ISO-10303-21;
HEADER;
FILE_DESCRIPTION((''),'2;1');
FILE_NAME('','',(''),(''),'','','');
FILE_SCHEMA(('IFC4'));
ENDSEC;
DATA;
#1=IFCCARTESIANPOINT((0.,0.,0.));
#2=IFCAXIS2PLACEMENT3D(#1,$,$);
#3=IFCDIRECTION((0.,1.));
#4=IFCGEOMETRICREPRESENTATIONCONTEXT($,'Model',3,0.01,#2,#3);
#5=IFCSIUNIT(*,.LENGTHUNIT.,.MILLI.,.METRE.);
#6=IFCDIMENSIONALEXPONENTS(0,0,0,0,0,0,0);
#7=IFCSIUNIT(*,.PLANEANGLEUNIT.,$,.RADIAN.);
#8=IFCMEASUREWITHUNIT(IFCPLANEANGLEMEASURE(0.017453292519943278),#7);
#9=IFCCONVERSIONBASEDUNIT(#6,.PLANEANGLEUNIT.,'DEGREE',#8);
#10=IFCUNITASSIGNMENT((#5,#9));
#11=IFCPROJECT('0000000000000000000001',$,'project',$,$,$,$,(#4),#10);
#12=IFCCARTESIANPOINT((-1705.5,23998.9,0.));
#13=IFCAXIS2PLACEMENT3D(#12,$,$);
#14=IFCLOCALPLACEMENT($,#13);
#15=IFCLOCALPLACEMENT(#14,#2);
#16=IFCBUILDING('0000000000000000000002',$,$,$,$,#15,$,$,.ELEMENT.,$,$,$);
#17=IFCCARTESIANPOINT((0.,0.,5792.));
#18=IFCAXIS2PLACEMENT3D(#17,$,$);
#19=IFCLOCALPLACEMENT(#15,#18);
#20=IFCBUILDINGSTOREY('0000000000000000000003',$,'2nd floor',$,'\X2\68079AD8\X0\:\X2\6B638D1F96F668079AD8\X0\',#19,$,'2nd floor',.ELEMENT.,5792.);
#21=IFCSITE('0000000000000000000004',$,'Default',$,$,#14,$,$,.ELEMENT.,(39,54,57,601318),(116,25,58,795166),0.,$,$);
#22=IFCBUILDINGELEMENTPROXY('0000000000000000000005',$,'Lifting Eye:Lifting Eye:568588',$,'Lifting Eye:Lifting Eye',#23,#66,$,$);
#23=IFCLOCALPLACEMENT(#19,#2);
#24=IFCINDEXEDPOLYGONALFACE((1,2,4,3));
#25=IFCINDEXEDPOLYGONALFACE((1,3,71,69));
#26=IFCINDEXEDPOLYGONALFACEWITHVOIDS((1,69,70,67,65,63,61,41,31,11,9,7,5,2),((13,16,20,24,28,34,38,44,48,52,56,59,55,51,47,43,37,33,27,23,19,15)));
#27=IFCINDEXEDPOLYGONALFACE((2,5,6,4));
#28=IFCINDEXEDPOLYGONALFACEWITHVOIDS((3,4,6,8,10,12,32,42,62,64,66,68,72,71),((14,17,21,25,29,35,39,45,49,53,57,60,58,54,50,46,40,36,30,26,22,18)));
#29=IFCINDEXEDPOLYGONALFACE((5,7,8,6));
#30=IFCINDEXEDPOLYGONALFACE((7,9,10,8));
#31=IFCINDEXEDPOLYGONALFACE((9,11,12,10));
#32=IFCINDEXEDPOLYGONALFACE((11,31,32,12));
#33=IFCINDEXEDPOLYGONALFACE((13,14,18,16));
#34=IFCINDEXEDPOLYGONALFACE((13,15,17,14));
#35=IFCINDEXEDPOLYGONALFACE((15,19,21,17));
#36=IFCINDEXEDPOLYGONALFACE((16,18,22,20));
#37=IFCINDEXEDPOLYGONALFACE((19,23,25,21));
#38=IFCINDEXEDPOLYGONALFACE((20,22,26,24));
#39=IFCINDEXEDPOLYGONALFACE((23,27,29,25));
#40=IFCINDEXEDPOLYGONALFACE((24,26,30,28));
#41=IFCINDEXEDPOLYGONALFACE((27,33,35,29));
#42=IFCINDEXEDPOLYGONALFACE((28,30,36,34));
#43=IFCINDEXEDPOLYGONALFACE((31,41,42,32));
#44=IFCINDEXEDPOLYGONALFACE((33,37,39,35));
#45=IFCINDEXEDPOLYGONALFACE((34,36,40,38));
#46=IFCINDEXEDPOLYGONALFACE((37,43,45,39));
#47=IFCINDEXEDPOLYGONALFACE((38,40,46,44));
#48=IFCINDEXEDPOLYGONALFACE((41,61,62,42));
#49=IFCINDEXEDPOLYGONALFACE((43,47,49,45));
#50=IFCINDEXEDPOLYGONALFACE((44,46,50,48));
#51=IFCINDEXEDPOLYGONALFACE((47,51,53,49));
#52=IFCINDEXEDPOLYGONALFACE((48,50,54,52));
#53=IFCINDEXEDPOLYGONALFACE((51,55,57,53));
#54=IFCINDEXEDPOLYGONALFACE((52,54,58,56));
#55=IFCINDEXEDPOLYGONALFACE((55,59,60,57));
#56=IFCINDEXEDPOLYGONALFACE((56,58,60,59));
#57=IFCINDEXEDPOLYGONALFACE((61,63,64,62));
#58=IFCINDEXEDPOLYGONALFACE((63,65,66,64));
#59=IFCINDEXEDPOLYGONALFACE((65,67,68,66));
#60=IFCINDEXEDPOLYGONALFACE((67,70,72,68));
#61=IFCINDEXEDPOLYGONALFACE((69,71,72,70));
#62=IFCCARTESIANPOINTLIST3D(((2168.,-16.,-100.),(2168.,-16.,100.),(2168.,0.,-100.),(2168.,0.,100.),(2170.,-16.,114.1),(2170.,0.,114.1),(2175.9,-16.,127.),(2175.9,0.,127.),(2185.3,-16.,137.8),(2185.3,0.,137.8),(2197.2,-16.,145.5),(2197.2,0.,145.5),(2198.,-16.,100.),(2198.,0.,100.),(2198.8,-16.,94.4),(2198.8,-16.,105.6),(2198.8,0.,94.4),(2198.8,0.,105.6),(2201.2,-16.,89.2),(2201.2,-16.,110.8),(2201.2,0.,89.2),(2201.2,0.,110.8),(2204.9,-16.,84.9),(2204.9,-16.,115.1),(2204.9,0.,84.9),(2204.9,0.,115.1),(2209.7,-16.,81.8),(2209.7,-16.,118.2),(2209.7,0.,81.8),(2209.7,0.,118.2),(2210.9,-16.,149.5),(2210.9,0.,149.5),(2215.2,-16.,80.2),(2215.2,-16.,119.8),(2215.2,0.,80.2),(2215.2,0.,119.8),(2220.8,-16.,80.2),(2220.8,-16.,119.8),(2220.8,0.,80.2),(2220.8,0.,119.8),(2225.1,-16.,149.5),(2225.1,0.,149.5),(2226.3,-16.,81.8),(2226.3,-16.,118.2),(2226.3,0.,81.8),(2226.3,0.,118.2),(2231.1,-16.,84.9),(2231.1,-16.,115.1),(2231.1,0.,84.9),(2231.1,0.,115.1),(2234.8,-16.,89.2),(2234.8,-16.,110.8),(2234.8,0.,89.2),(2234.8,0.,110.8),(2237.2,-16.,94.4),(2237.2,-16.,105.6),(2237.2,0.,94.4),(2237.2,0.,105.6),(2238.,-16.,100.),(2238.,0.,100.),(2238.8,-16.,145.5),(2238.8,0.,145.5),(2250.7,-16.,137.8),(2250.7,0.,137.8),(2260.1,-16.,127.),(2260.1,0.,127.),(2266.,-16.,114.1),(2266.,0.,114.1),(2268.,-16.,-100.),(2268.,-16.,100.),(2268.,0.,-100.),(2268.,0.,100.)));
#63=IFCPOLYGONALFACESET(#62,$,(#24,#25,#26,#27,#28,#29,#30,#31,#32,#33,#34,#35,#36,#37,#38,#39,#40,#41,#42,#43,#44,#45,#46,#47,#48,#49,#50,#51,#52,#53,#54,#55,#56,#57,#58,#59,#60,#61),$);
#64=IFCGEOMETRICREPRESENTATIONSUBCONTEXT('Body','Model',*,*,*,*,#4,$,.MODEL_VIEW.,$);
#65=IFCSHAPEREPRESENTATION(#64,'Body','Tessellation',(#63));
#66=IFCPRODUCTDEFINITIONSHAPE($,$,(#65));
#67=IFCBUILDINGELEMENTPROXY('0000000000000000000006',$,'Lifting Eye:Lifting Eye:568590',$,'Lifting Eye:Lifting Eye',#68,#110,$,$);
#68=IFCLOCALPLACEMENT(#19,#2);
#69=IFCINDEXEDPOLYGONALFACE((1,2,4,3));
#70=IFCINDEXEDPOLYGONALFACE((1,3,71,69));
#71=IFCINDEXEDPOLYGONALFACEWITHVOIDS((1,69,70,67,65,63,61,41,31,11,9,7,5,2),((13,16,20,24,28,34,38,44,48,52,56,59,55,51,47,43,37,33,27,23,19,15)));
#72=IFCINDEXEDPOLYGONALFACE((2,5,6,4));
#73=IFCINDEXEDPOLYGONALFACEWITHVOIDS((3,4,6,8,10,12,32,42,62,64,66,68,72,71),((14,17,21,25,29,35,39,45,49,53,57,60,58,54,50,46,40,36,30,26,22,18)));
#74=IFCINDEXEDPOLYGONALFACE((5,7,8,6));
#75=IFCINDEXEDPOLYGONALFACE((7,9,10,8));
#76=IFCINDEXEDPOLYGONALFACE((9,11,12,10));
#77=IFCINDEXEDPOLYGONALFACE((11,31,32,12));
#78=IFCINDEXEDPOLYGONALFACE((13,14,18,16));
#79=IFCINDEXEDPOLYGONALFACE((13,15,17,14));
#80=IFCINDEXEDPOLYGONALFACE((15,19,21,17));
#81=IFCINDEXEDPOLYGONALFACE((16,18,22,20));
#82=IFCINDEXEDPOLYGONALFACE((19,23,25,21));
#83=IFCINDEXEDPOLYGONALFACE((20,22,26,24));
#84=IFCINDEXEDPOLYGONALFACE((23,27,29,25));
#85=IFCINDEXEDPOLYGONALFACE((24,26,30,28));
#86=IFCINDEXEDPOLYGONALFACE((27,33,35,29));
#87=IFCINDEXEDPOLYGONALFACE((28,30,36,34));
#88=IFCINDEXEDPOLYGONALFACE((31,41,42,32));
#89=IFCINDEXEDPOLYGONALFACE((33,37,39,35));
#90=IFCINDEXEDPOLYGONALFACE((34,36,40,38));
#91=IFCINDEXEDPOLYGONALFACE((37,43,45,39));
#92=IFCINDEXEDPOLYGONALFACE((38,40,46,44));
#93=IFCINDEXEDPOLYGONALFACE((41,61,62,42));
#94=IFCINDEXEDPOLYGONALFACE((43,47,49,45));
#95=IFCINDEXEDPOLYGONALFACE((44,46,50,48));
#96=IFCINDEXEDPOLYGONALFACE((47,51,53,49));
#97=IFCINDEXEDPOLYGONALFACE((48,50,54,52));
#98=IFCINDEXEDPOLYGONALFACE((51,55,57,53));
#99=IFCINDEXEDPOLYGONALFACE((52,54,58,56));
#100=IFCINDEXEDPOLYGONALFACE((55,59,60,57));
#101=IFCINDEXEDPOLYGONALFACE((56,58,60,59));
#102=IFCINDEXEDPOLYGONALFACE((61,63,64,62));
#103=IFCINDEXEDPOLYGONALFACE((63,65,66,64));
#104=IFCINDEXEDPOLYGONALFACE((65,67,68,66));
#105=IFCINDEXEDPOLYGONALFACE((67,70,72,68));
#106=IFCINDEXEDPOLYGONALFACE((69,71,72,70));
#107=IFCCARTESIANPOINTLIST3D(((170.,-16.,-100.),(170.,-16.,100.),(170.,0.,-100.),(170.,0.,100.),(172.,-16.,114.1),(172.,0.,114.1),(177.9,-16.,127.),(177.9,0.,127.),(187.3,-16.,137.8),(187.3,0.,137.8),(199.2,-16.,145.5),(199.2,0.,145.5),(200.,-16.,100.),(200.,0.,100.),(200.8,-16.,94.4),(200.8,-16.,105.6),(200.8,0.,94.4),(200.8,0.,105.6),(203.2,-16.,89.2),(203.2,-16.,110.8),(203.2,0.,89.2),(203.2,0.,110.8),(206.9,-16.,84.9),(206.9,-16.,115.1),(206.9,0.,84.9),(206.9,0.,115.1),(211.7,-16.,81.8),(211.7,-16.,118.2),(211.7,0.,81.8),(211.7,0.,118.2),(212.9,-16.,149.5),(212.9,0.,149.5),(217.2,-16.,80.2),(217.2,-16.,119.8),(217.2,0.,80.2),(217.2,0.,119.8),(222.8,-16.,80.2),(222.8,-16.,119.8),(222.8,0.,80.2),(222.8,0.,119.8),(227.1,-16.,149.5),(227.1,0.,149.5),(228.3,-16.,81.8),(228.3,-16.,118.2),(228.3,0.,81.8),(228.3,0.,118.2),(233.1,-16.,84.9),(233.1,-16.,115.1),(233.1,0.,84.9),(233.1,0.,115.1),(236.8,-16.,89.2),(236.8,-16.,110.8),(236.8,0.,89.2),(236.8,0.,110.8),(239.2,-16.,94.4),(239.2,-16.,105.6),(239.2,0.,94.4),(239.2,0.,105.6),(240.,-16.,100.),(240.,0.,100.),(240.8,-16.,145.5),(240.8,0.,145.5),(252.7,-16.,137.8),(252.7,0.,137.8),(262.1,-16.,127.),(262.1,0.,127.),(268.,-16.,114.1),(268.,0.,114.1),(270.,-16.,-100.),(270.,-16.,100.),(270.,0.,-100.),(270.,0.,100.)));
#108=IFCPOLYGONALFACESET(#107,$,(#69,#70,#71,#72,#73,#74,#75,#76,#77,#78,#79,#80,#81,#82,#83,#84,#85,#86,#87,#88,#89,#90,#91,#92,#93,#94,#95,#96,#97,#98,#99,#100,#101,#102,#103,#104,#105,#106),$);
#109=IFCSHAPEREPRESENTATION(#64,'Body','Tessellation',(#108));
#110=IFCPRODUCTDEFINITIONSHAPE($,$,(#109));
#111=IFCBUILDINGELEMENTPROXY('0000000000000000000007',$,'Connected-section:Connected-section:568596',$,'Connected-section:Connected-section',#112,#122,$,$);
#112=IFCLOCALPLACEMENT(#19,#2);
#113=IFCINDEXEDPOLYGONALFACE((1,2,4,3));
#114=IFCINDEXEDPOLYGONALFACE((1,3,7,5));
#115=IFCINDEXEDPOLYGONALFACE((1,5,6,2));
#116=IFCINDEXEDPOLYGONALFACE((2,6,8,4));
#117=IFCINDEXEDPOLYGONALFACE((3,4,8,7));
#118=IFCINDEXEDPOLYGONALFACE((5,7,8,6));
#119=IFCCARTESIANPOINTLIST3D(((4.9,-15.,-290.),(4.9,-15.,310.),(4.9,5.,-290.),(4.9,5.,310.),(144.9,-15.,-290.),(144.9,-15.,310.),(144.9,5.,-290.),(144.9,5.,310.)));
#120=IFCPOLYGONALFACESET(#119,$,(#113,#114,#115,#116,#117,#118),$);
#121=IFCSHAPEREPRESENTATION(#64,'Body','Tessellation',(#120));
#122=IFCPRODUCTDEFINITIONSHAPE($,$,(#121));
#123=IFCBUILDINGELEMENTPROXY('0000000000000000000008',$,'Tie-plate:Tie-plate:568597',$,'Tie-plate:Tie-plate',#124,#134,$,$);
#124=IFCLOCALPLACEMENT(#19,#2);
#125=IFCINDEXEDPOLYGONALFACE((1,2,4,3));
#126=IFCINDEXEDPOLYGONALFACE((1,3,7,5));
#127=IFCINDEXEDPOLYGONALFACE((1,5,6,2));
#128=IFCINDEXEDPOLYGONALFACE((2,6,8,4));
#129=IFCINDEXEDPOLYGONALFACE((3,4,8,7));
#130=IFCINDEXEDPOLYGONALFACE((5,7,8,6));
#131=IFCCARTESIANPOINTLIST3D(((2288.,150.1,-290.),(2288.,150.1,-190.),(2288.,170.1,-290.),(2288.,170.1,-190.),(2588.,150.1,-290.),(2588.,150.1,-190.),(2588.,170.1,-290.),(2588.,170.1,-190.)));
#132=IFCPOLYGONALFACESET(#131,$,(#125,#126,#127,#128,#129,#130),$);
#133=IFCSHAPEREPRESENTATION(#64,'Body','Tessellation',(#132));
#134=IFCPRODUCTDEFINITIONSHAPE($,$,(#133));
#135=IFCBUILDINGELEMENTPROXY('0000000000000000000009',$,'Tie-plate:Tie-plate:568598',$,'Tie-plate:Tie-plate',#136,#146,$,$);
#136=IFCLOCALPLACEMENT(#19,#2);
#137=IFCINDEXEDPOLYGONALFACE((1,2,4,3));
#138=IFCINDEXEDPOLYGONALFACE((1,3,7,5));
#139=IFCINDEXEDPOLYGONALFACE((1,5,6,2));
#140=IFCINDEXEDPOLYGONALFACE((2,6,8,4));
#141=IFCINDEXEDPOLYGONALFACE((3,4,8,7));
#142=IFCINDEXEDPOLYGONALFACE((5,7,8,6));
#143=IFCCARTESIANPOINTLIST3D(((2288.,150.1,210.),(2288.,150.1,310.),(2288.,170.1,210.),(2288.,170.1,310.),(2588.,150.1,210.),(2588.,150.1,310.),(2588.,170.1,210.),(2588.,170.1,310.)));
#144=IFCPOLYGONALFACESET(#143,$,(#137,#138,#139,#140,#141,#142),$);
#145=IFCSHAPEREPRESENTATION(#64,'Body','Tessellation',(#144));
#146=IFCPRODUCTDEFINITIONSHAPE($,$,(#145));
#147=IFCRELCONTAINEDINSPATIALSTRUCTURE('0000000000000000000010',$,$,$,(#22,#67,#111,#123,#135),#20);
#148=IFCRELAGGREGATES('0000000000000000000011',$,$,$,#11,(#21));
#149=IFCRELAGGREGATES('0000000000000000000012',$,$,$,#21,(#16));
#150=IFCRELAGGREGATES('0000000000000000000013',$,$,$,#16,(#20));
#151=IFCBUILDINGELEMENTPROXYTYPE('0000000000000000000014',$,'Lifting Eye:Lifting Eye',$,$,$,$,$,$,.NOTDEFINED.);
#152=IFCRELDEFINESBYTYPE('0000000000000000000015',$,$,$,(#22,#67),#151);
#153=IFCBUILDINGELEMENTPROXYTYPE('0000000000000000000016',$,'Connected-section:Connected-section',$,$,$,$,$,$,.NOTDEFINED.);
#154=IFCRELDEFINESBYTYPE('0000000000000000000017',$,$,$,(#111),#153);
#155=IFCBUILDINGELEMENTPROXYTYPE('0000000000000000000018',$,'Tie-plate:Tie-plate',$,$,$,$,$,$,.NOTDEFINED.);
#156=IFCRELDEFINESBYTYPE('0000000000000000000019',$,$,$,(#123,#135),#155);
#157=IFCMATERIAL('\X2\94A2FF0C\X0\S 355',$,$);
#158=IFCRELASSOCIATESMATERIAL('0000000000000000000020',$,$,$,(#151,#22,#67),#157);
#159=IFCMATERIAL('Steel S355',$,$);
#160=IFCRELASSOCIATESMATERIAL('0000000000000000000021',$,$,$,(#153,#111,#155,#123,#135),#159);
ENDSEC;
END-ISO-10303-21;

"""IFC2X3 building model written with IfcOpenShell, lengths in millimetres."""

from ifc_helpers import new_model, entity, si_unit, converted_unit, direction, frame, frame_2d, origin, place, context, subcontext, project, spatial, polyline, circle_curve, parameter, trimmed, segment, composite_curve, rectangle, outline, extrude, source, transform, mapped, material, type_object, type_shapes, element, save


model = new_model("IFC2X3")

# Units and contexts
model_context = context("Model", 3, precision=0.01, world=origin(), true_north=direction((0.0, 1.0)))
body_context = subcontext(model_context, "Body", "Model", "MODEL_VIEW")
ifc_project = project(units=[si_unit("LENGTHUNIT", "METRE", prefix="MILLI"), converted_unit("PLANEANGLEUNIT", "DEGREE", entity("IfcPlaneAngleMeasure", 0.017453292519943278), si_unit("PLANEANGLEUNIT", "RADIAN"), dimensions=[0, 0, 0, 0, 0, 0, 0])], contexts=[model_context])

# Site, building, storey
site_placement = place(None, frame((-1705.5, 23998.9, 0.0)))
site = spatial("IfcSite", under=ifc_project, at=site_placement, Name="Default", CompositionType="ELEMENT", RefLatitude=(39, 54, 57, 601318), RefLongitude=(116, 25, 58, 795166), RefElevation=0.0)
building_placement = place(site_placement, origin())
building = spatial("IfcBuilding", under=site, at=building_placement, CompositionType="ELEMENT")
storey_placement = place(building_placement, frame((0.0, 0.0, 5792.0)))
storey = spatial("IfcBuildingStorey", under=building, at=storey_placement, Name="2nd floor", ObjectType="标高:正负零标高", LongName="2nd floor", CompositionType="ELEMENT", Elevation=5792.0)

# Shared definitions
ifc_material_1 = material(Name="Steel S355")

# Building element proxies
ifc_material_2 = material(Name="钢，S 355")
building_element_proxy_type_1 = type_object("IfcBuildingElementProxyType", Name="Lifting Eye:Lifting Eye", PredefinedType="NOTDEFINED", material=ifc_material_2)
shared_shape_1 = source(origin(), body_context, "Body", "SweptSolid", [
    extrude(outline(composite_curve([segment(polyline([(-100.0, -50.0), (100.0, -50.0)]), True, "CONTINUOUS"), segment(polyline([(100.0, -50.0), (100.0, 50.0)]), True, "CONTINUOUS"), segment(polyline([(100.0, 50.0), (-100.0, 50.0)]), True, "CONTINUOUS"), segment(trimmed(circle_curve(frame_2d((-100.0, 0.0), x_axis=(0.0, -1.0)), 50.0), [parameter(180.0)], [parameter(0.0)], True, "PARAMETER"), True, "CONTINUOUS")], self_intersect=False), holes=[composite_curve([segment(trimmed(circle_curve(frame_2d((-100.0, 0.0), x_axis=(0.0, -1.0)), 20.0), [parameter(180.0)], [parameter(360.0)], True, "PARAMETER"), False, "CONTINUOUS"), segment(trimmed(circle_curve(frame_2d((-100.0, 0.0), x_axis=(0.0, -1.0)), 20.0), [parameter(0.0)], [parameter(180.0)], True, "PARAMETER"), False, "CONTINUOUS")], self_intersect=False)]), frame((0.0, 17.0, -17.0), z_axis=(0.0, 1.0, 0.0), x_axis=(0.0, 0.0, -1.0)), (0.0, 0.0, 1.0), 16.0),
])
type_shapes(building_element_proxy_type_1, [shared_shape_1])
for number, where, name in (
    (1, (2218.0, -33.0, 17.0), "Lifting Eye:Lifting Eye:568588"),
    (2, (220.0, -33.0, 17.0), "Lifting Eye:Lifting Eye:568590"),
):
    element("IfcBuildingElementProxy", number, at=place(storey_placement, frame(where)), inside=storey, type_object=building_element_proxy_type_1, material=ifc_material_2, Name=name, ObjectType="Lifting Eye:Lifting Eye", context=body_context, shape_type="MappedRepresentation", body=[
        mapped(shared_shape_1, transform((0.0, 0.0, 0.0), scale=1.0)),
    ])
building_element_proxy_type_2 = type_object("IfcBuildingElementProxyType", Name="Connected-section:Connected-section", PredefinedType="NOTDEFINED", material=ifc_material_1)
shared_shape_2 = source(origin(), body_context, "Body", "SweptSolid", [
    extrude(rectangle(XDim=20.0, YDim=140.0, at=frame_2d((0.0, 0.0), x_axis=(1.0, 0.0))), frame((70.0, 10.0, 0.0), z_axis=(0.0, 0.0, 1.0), x_axis=(0.0, 1.0, 0.0)), (0.0, 0.0, 1.0), 600.0),
])
type_shapes(building_element_proxy_type_2, [shared_shape_2])
proxy_1_placement = place(storey_placement, frame((4.9, -15.0, -290.0)))
element("IfcBuildingElementProxy", 3, at=proxy_1_placement, inside=storey, type_object=building_element_proxy_type_2, material=ifc_material_1, Name="Connected-section:Connected-section:568596", ObjectType="Connected-section:Connected-section", context=body_context, shape_type="MappedRepresentation", body=[
    mapped(shared_shape_2, transform((0.0, 0.0, 0.0), scale=1.0)),
])
building_element_proxy_type_3 = type_object("IfcBuildingElementProxyType", Name="Tie-plate:Tie-plate", PredefinedType="NOTDEFINED", material=ifc_material_1)
shared_shape_3 = source(origin(), body_context, "Body", "SweptSolid", [
    extrude(rectangle(XDim=20.0, YDim=300.0, at=frame_2d((0.0, 0.0), x_axis=(1.0, 0.0))), frame((150.0, 10.0, 0.0), z_axis=(0.0, 0.0, 1.0), x_axis=(0.0, 1.0, 0.0)), (0.0, 0.0, 1.0), 100.0),
])
type_shapes(building_element_proxy_type_3, [shared_shape_3])
for number, where, name in (
    (4, (2288.0, 150.1, -290.0), "Tie-plate:Tie-plate:568597"),
    (5, (2288.0, 150.1, 210.0), "Tie-plate:Tie-plate:568598"),
):
    element("IfcBuildingElementProxy", number, at=place(storey_placement, frame(where)), inside=storey, type_object=building_element_proxy_type_3, material=ifc_material_1, Name=name, ObjectType="Tie-plate:Tie-plate", context=body_context, shape_type="MappedRepresentation", body=[
        mapped(shared_shape_3, transform((0.0, 0.0, 0.0), scale=1.0)),
    ])

save(model, "model.ifc")
